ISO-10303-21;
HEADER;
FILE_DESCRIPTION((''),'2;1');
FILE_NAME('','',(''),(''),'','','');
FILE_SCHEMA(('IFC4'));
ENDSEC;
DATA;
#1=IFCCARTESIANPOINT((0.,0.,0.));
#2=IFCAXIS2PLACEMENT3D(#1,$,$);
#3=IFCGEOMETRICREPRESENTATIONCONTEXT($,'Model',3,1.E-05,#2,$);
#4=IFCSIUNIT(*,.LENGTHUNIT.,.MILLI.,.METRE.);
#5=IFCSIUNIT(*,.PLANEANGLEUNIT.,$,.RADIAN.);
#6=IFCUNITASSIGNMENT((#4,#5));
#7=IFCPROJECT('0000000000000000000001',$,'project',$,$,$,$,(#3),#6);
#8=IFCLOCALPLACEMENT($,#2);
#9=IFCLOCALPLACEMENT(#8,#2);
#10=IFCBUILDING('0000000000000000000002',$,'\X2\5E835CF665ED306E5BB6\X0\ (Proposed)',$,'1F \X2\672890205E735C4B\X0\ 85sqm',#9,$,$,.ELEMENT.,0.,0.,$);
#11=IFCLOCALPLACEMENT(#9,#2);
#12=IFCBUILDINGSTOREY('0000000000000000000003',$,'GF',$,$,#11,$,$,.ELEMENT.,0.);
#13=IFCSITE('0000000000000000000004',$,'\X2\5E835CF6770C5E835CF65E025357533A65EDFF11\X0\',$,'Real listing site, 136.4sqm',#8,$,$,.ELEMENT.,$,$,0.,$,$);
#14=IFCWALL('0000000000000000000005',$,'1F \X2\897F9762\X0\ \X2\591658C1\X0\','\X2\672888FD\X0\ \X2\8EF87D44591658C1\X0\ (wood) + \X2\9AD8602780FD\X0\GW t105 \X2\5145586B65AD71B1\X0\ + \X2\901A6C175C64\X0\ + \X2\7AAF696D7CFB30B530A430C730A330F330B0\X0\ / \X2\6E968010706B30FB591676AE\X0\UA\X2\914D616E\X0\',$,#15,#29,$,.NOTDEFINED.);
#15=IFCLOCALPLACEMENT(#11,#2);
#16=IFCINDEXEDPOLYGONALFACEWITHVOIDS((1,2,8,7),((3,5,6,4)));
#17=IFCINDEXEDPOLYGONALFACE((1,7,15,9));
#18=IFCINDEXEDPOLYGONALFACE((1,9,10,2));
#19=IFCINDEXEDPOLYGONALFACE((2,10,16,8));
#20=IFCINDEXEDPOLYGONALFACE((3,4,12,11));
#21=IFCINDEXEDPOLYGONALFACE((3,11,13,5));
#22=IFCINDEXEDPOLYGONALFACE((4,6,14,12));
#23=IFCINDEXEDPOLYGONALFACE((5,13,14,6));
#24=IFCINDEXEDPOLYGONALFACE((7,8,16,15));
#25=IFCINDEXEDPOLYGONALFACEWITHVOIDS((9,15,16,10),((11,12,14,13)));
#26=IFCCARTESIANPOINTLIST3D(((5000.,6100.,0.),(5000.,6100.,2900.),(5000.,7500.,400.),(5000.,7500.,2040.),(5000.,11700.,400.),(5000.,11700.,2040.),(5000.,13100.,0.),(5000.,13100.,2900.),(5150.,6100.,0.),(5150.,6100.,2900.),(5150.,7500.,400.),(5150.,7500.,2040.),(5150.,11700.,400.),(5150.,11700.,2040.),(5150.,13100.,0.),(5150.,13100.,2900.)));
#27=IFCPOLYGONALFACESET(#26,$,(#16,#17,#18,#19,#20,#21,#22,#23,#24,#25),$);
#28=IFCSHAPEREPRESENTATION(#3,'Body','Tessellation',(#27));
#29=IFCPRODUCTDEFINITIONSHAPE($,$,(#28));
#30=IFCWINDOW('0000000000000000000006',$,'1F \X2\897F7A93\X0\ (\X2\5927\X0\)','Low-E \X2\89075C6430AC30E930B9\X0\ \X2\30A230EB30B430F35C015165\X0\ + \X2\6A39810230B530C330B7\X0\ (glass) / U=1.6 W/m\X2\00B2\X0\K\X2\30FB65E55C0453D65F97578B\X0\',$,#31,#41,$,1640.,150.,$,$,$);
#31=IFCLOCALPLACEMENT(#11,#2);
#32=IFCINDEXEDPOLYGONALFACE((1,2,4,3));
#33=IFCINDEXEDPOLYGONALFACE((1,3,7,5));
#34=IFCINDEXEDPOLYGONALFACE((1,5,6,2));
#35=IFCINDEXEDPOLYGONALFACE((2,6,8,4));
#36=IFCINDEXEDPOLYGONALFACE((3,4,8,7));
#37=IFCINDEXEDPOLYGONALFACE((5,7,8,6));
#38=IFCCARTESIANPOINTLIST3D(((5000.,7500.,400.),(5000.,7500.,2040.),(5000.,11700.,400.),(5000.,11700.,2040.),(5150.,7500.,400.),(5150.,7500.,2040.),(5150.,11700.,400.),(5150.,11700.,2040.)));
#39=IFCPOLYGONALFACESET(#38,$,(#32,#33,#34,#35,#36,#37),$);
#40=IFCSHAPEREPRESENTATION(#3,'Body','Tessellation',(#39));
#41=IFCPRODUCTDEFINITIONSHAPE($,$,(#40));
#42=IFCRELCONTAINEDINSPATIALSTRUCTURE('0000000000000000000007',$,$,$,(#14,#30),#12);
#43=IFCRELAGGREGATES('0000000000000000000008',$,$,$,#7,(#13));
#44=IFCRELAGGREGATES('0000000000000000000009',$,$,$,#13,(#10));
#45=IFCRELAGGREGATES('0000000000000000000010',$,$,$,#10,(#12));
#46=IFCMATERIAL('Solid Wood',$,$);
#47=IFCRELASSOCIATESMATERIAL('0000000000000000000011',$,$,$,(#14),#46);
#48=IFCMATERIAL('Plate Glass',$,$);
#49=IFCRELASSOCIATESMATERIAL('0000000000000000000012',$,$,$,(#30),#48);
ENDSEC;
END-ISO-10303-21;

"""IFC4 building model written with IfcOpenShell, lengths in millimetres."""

from ifc_helpers import new_model, si_unit, frame, frame_2d, origin, place, context, project, spatial, rectangle, extrude, material, element, fill, save


model = new_model("IFC4")

# Units and contexts
model_context = context("Model", 3, precision=1e-05, world=origin())
ifc_project = project(units=[si_unit("LENGTHUNIT", "METRE", prefix="MILLI"), si_unit("PLANEANGLEUNIT", "RADIAN")], contexts=[model_context])

# Site, building, storey
site_placement = place(None, origin())
site = spatial("IfcSite", under=ifc_project, at=site_placement, Name="広島県広島市南区旭１", ObjectType="Real listing site, 136.4sqm", CompositionType="ELEMENT", RefElevation=0.0)
building_placement = place(site_placement, origin())
building = spatial("IfcBuilding", under=site, at=building_placement, Name="広島旭の家 (Proposed)", ObjectType="1F 木造平屋 85sqm", CompositionType="ELEMENT", ElevationOfRefHeight=0.0, ElevationOfTerrain=0.0)
storey_placement = place(building_placement, origin())
storey = spatial("IfcBuildingStorey", under=building, at=storey_placement, Name="GF", CompositionType="ELEMENT", Elevation=0.0)

# Shared definitions
ifc_material_1 = material(Name="Solid Wood")

# Shared definitions
ifc_material_2 = material(Name="Plate Glass")

# Wall, opening, window
wall_1_placement = place(storey_placement, frame((2500.0, 3050.0, 0.0)))
wall_1 = element("IfcWall", 1, at=wall_1_placement, inside=storey, material=ifc_material_1, Name="1F 西面 外壁", Description="木製 軸組外壁 (wood) + 高性能GW t105 充填断熱 + 通気層 + 窯業系サイディング / 準耐火・外皮UA配慮", PredefinedType="NOTDEFINED", context=model_context, shape_type="SweptSolid", body=[
    extrude(rectangle(XDim=150.0, YDim=7000.0, at=frame_2d((75.0, 3500.0))), frame((2500.0, 3050.0, 0.0)), (0.0, 0.0, 1.0), 2900.0),
])
opening_1_placement = place(storey_placement, frame((2500.0, 3750.0, 200.0)))
opening_1 = element("IfcOpeningElement", 2, at=opening_1_placement, cuts=wall_1, PredefinedType="NOTDEFINED", context=model_context, shape_type="SweptSolid", body=[
    extrude(rectangle(XDim=150.0, YDim=4200.0, at=frame_2d((75.0, 2100.0))), frame((2500.0, 3750.0, 200.0)), (0.0, 0.0, 1.0), 1640.0),
])
window_1_placement = place(storey_placement, frame((2500.0, 3750.0, 200.0)))
window_1 = element("IfcWindow", 3, at=window_1_placement, inside=storey, material=ifc_material_2, Name="1F 西窓 (大)", Description="Low-E 複層ガラス アルゴン封入 + 樹脂サッシ (glass) / U=1.6 W/m²K・日射取得型", OverallHeight=1640.0, OverallWidth=150.0, context=model_context, shape_type="SweptSolid", body=[
    extrude(rectangle(XDim=150.0, YDim=4200.0, at=frame_2d((75.0, 2100.0))), frame((2500.0, 3750.0, 200.0)), (0.0, 0.0, 1.0), 1640.0),
])
fill(opening_1, window_1)

save(model, "model.ifc")
